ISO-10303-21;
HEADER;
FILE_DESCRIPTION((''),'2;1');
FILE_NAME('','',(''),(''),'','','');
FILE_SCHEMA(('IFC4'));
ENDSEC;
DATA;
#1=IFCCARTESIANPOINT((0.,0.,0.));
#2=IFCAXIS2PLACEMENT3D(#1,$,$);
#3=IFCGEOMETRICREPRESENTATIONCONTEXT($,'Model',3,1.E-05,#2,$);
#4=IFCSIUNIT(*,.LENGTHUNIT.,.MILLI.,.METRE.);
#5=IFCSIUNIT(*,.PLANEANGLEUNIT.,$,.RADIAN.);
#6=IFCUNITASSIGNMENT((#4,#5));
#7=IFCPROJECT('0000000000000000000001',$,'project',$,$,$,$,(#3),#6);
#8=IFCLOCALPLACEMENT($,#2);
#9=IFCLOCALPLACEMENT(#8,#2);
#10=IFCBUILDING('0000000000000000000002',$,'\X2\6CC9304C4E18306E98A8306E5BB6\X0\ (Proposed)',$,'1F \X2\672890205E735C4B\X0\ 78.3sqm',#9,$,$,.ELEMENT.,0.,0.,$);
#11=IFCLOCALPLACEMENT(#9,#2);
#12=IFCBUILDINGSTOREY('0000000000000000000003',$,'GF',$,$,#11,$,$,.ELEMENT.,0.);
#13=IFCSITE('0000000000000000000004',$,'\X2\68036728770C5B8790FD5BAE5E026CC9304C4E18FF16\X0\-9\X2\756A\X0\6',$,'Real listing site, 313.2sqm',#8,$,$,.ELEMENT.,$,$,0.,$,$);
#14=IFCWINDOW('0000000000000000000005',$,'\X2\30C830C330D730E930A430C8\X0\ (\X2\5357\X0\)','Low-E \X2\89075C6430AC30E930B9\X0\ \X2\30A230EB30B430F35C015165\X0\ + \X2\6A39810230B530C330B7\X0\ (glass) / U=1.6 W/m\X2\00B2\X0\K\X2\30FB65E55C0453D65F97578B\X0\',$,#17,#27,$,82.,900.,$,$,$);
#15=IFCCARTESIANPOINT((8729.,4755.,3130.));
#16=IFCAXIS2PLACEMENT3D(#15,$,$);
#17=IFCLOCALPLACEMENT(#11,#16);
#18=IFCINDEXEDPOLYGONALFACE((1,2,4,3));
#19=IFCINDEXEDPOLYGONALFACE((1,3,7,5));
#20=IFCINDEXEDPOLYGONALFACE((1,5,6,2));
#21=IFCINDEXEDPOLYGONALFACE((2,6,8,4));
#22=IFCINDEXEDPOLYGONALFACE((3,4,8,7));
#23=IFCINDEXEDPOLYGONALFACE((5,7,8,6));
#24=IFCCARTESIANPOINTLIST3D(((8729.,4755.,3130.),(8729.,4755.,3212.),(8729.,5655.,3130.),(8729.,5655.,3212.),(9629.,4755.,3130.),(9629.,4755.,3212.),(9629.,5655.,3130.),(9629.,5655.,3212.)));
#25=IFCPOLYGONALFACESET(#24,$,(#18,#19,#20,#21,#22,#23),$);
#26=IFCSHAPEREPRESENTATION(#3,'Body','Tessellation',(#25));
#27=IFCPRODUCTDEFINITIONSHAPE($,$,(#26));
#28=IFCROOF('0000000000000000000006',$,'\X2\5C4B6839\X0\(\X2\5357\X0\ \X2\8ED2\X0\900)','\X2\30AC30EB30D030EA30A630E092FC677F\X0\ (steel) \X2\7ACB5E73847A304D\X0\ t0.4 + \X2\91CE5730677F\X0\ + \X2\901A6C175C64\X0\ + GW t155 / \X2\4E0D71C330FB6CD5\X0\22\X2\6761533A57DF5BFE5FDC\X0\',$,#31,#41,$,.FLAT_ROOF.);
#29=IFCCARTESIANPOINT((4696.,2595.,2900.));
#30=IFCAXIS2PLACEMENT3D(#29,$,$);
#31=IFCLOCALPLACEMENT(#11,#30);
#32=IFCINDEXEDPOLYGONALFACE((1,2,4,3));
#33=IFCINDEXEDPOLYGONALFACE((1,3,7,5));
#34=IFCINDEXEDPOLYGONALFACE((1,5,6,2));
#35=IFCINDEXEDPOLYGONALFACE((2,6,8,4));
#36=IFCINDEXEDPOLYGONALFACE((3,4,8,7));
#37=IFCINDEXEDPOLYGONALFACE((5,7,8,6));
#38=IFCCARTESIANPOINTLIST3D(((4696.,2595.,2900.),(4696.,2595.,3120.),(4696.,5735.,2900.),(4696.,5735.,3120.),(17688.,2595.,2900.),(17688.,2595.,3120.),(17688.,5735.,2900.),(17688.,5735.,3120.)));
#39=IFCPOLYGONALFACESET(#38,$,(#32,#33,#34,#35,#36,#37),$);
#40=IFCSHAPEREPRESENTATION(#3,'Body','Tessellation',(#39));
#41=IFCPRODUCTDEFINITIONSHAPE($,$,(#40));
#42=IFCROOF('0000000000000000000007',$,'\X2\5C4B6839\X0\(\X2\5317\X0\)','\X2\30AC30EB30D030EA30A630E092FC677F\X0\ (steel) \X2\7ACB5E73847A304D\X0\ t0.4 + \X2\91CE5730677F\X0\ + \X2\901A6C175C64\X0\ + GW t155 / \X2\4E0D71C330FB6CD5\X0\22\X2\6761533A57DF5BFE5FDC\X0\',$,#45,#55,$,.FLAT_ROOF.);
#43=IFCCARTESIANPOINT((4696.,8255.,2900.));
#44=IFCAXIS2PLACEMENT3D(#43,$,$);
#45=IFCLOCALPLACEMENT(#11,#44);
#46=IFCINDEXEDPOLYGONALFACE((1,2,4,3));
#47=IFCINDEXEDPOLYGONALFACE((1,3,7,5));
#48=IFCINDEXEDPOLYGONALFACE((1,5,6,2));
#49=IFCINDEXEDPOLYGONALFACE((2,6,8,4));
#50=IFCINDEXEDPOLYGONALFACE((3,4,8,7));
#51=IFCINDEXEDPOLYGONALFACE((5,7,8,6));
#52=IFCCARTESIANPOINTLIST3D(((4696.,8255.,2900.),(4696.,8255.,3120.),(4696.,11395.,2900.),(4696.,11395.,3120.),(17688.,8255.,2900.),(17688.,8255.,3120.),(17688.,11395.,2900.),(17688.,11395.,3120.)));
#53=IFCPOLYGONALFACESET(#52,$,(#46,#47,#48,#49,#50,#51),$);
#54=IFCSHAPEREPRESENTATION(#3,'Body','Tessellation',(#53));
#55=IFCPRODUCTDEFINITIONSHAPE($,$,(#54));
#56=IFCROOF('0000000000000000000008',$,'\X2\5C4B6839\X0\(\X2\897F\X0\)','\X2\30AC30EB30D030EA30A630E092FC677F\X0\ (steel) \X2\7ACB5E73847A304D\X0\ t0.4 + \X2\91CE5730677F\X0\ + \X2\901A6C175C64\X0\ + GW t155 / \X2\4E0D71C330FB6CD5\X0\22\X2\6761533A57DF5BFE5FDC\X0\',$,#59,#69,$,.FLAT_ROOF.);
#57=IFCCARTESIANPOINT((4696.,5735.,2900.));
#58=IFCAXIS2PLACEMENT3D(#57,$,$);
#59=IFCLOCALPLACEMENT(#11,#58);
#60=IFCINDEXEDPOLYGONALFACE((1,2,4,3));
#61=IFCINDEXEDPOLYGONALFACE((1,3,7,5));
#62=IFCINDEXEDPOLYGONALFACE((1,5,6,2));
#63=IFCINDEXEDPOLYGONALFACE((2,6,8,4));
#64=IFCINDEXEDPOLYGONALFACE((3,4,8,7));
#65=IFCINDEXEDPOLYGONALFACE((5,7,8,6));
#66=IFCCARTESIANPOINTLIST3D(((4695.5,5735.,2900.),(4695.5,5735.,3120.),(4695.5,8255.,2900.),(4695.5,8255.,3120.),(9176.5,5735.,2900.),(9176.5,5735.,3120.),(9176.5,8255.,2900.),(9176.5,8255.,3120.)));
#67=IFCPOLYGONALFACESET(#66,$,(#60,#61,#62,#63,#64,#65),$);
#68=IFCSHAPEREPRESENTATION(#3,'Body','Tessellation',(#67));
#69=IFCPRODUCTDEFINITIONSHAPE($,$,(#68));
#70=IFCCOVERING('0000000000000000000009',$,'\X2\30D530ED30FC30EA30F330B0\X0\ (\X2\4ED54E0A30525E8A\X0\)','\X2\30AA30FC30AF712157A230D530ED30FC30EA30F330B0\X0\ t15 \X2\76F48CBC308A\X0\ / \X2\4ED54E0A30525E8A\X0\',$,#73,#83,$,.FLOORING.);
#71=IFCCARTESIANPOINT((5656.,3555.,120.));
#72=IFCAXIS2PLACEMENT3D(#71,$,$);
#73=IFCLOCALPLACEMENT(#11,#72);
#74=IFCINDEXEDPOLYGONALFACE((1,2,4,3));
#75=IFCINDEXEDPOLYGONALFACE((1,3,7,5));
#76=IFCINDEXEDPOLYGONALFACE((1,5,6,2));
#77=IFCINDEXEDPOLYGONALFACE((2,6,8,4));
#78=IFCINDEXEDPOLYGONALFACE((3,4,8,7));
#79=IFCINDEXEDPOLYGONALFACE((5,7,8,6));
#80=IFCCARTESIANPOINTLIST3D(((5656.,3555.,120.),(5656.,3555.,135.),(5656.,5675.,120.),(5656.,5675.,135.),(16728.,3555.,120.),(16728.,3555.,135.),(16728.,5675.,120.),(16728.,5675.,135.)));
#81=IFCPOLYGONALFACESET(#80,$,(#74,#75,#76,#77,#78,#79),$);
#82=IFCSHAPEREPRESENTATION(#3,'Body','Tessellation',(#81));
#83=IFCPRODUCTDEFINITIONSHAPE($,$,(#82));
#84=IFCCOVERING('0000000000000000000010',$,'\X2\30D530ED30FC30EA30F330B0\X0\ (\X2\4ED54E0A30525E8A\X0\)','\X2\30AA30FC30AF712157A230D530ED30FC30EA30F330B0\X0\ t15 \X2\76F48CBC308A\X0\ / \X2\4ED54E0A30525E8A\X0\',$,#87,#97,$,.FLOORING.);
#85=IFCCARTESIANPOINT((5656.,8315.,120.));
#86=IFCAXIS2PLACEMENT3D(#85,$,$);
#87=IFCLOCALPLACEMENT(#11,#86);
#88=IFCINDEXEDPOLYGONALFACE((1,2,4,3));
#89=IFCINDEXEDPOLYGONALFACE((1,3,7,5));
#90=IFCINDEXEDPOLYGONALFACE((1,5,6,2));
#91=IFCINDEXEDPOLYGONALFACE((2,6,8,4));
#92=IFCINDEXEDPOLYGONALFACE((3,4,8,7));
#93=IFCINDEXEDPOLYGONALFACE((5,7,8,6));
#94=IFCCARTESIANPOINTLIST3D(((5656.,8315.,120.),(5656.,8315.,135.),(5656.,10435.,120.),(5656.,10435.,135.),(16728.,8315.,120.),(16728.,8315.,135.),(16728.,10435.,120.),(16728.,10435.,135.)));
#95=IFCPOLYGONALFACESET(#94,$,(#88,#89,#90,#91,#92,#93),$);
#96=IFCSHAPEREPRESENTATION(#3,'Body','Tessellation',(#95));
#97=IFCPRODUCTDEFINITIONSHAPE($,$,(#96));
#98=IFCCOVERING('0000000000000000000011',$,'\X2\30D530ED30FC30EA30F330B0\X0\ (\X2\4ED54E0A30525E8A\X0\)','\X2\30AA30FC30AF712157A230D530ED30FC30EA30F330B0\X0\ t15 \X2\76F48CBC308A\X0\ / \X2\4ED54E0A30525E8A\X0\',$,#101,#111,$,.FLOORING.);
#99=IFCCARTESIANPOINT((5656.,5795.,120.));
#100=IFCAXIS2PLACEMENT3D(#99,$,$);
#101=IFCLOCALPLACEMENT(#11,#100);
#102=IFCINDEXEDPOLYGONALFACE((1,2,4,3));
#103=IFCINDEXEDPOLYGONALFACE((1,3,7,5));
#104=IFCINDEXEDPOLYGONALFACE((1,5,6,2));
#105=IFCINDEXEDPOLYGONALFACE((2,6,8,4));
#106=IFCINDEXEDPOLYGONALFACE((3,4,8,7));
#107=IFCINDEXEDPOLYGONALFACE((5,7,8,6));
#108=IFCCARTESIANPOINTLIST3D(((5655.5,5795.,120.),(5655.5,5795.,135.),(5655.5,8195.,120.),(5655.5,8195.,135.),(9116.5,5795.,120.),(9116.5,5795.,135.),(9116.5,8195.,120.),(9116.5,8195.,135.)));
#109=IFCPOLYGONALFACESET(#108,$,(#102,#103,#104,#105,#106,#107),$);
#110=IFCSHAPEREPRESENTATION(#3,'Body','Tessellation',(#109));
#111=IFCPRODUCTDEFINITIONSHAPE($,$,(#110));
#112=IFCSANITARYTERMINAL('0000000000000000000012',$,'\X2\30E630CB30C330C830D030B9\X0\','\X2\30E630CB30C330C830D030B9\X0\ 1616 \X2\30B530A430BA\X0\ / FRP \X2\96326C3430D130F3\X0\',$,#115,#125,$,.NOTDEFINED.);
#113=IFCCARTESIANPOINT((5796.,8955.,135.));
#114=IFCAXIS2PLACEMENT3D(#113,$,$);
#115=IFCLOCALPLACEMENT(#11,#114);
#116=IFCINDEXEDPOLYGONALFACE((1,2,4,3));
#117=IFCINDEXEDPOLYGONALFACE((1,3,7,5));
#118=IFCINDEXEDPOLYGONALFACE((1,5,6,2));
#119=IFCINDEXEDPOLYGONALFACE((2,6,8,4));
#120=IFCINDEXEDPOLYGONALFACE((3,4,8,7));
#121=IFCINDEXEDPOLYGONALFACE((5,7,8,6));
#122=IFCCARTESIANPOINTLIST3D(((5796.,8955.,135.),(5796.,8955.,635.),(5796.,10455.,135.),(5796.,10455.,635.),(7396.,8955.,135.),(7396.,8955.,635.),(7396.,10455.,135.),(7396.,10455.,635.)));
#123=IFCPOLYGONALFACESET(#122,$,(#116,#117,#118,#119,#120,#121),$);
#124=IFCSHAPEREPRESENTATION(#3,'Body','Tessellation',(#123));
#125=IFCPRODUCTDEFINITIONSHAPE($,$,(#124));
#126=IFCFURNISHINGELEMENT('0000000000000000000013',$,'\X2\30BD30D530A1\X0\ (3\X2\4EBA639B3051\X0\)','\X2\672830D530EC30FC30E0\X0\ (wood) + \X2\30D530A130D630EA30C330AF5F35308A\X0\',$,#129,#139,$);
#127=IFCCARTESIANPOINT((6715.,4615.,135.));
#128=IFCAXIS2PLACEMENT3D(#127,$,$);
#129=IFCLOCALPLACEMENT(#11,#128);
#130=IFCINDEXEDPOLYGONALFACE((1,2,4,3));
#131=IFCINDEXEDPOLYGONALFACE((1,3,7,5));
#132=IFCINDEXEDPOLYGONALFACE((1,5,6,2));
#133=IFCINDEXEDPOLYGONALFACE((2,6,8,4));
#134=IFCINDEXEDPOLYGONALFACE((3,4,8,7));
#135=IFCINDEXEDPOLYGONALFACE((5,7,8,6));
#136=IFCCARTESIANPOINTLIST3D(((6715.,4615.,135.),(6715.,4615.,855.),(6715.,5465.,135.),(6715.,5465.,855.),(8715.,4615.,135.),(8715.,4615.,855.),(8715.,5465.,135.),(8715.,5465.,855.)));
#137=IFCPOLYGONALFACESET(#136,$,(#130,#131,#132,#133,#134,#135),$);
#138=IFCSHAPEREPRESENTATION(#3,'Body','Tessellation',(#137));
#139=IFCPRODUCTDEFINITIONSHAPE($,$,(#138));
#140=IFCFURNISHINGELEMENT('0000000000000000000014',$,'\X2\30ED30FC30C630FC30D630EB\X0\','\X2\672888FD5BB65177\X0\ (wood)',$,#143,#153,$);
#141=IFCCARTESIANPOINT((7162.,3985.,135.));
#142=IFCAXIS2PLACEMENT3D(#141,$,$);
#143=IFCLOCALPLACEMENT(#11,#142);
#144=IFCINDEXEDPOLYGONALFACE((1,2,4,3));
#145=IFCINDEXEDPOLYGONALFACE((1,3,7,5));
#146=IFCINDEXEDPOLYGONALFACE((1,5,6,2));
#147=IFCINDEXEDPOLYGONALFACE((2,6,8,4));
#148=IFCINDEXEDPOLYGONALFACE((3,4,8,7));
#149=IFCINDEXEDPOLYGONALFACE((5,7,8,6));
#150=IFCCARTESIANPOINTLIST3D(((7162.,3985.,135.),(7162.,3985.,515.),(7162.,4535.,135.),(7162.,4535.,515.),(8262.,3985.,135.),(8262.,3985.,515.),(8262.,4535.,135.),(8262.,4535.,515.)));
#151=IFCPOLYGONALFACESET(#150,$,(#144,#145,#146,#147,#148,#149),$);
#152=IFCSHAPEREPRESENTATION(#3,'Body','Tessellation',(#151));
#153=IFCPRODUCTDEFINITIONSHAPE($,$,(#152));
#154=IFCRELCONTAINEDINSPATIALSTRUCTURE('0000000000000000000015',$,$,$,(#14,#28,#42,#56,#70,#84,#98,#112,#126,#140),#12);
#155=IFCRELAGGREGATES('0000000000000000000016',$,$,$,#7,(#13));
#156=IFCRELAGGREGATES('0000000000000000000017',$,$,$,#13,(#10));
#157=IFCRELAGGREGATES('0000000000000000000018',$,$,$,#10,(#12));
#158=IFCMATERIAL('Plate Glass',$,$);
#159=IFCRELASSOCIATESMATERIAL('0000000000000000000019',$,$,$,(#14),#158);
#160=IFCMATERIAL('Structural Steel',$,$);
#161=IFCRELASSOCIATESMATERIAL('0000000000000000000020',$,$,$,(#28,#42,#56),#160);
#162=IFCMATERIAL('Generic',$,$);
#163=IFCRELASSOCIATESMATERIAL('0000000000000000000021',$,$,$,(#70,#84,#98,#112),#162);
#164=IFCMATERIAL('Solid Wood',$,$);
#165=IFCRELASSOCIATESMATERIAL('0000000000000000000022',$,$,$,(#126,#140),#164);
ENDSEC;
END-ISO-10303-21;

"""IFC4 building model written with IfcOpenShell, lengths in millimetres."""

from ifc_helpers import new_model, si_unit, frame, frame_2d, origin, place, context, project, spatial, rectangle, extrude, material, element, save


model = new_model("IFC4")

# Units and contexts
model_context = context("Model", 3, precision=1e-05, world=origin())
ifc_project = project(units=[si_unit("LENGTHUNIT", "METRE", prefix="MILLI"), si_unit("PLANEANGLEUNIT", "RADIAN")], contexts=[model_context])

# Site, building, storey
site_placement = place(None, origin())
site = spatial("IfcSite", under=ifc_project, at=site_placement, Name="栃木県宇都宮市泉が丘６-9番6", ObjectType="Real listing site, 313.2sqm", CompositionType="ELEMENT", RefElevation=0.0)
building_placement = place(site_placement, origin())
building = spatial("IfcBuilding", under=site, at=building_placement, Name="泉が丘の風の家 (Proposed)", ObjectType="1F 木造平屋 78.3sqm", CompositionType="ELEMENT", ElevationOfRefHeight=0.0, ElevationOfTerrain=0.0)
storey_placement = place(building_placement, origin())
storey = spatial("IfcBuildingStorey", under=building, at=storey_placement, Name="GF", CompositionType="ELEMENT", Elevation=0.0)

# Shared definitions
ifc_material_1 = material(Name="Solid Wood")

# Shared definitions
ifc_material_2 = material(Name="Plate Glass")

# Window
window_1_placement = place(storey_placement, frame((8729.0, 4755.0, 3130.0)))
element("IfcWindow", 1, at=window_1_placement, inside=storey, material=ifc_material_2, Name="トップライト (南)", Description="Low-E 複層ガラス アルゴン封入 + 樹脂サッシ (glass) / U=1.6 W/m²K・日射取得型", OverallHeight=82.0, OverallWidth=900.0, context=model_context, shape_type="SweptSolid", body=[
    extrude(rectangle(XDim=900.0, YDim=900.0, at=frame_2d((450.0, 450.0))), frame((8729.0, 4755.0, 3130.0)), (0.0, 0.0, 1.0), 82.0),
])

# Roofs
ifc_material_3 = material(Name="Structural Steel")
roof_1_placement = place(storey_placement, frame((4696.0, 2595.0, 2900.0)))
element("IfcRoof", 2, at=roof_1_placement, inside=storey, material=ifc_material_3, Name="屋根(南 軒900)", Description="ガルバリウム鋼板 (steel) 立平葺き t0.4 + 野地板 + 通気層 + GW t155 / 不燃・法22条区域対応", PredefinedType="FLAT_ROOF", context=model_context, shape_type="SweptSolid", body=[
    extrude(rectangle(XDim=12992.0, YDim=3140.0, at=frame_2d((6496.0, 1570.0))), frame((4696.0, 2595.0, 2900.0)), (0.0, 0.0, 1.0), 220.0),
])
roof_2_placement = place(storey_placement, frame((4696.0, 8255.0, 2900.0)))
element("IfcRoof", 3, at=roof_2_placement, inside=storey, material=ifc_material_3, Name="屋根(北)", Description="ガルバリウム鋼板 (steel) 立平葺き t0.4 + 野地板 + 通気層 + GW t155 / 不燃・法22条区域対応", PredefinedType="FLAT_ROOF", context=model_context, shape_type="SweptSolid", body=[
    extrude(rectangle(XDim=12992.0, YDim=3140.0, at=frame_2d((6496.0, 1570.0))), frame((4696.0, 8255.0, 2900.0)), (0.0, 0.0, 1.0), 220.0),
])
roof_3_placement = place(storey_placement, frame((4696.0, 5735.0, 2900.0)))
element("IfcRoof", 4, at=roof_3_placement, inside=storey, material=ifc_material_3, Name="屋根(西)", Description="ガルバリウム鋼板 (steel) 立平葺き t0.4 + 野地板 + 通気層 + GW t155 / 不燃・法22条区域対応", PredefinedType="FLAT_ROOF", context=model_context, shape_type="SweptSolid", body=[
    extrude(rectangle(XDim=4481.0, YDim=2520.0, at=frame_2d((2240.0, 1260.0))), frame((4696.0, 5735.0, 2900.0)), (0.0, 0.0, 1.0), 220.0),
])

# Coverings
ifc_material_4 = material(Name="Generic")
covering_1_placement = place(storey_placement, frame((5656.0, 3555.0, 120.0)))
element("IfcCovering", 5, at=covering_1_placement, inside=storey, material=ifc_material_4, Name="フローリング (仕上げ床)", Description="オーク無垢フローリング t15 直貼り / 仕上げ床", PredefinedType="FLOORING", context=model_context, shape_type="SweptSolid", body=[
    extrude(rectangle(XDim=11072.0, YDim=2120.0, at=frame_2d((5536.0, 1060.0))), frame((5656.0, 3555.0, 120.0)), (0.0, 0.0, 1.0), 15.0),
])
covering_2_placement = place(storey_placement, frame((5656.0, 8315.0, 120.0)))
element("IfcCovering", 6, at=covering_2_placement, inside=storey, material=ifc_material_4, Name="フローリング (仕上げ床)", Description="オーク無垢フローリング t15 直貼り / 仕上げ床", PredefinedType="FLOORING", context=model_context, shape_type="SweptSolid", body=[
    extrude(rectangle(XDim=11072.0, YDim=2120.0, at=frame_2d((5536.0, 1060.0))), frame((5656.0, 8315.0, 120.0)), (0.0, 0.0, 1.0), 15.0),
])
covering_3_placement = place(storey_placement, frame((5656.0, 5795.0, 120.0)))
element("IfcCovering", 7, at=covering_3_placement, inside=storey, material=ifc_material_4, Name="フローリング (仕上げ床)", Description="オーク無垢フローリング t15 直貼り / 仕上げ床", PredefinedType="FLOORING", context=model_context, shape_type="SweptSolid", body=[
    extrude(rectangle(XDim=3461.0, YDim=2400.0, at=frame_2d((1730.0, 1200.0))), frame((5656.0, 5795.0, 120.0)), (0.0, 0.0, 1.0), 15.0),
])

# Sanitary terminal
sanitary_terminal_placement = place(storey_placement, frame((5796.0, 8955.0, 135.0)))
element("IfcSanitaryTerminal", 8, at=sanitary_terminal_placement, inside=storey, material=ifc_material_4, Name="ユニットバス", Description="ユニットバス 1616 サイズ / FRP 防水パン", PredefinedType="NOTDEFINED", context=model_context, shape_type="SweptSolid", body=[
    extrude(rectangle(XDim=1600.0, YDim=1500.0, at=frame_2d((800.0, 750.0))), frame((5796.0, 8955.0, 135.0)), (0.0, 0.0, 1.0), 500.0),
])

# Furnishing elements
furnishing_1_placement = place(storey_placement, frame((6715.0, 4615.0, 135.0)))
element("IfcFurnishingElement", 9, at=furnishing_1_placement, inside=storey, material=ifc_material_1, Name="ソファ (3人掛け)", Description="木フレーム (wood) + ファブリック張り", context=model_context, shape_type="SweptSolid", body=[
    extrude(rectangle(XDim=2000.0, YDim=850.0, at=frame_2d((1000.0, 425.0))), frame((6715.0, 4615.0, 135.0)), (0.0, 0.0, 1.0), 720.0),
])
furnishing_2_placement = place(storey_placement, frame((7162.0, 3985.0, 135.0)))
element("IfcFurnishingElement", 10, at=furnishing_2_placement, inside=storey, material=ifc_material_1, Name="ローテーブル", Description="木製家具 (wood)", context=model_context, shape_type="SweptSolid", body=[
    extrude(rectangle(XDim=1100.0, YDim=550.0, at=frame_2d((550.0, 275.0))), frame((7162.0, 3985.0, 135.0)), (0.0, 0.0, 1.0), 380.0),
])

save(model, "model.ifc")
